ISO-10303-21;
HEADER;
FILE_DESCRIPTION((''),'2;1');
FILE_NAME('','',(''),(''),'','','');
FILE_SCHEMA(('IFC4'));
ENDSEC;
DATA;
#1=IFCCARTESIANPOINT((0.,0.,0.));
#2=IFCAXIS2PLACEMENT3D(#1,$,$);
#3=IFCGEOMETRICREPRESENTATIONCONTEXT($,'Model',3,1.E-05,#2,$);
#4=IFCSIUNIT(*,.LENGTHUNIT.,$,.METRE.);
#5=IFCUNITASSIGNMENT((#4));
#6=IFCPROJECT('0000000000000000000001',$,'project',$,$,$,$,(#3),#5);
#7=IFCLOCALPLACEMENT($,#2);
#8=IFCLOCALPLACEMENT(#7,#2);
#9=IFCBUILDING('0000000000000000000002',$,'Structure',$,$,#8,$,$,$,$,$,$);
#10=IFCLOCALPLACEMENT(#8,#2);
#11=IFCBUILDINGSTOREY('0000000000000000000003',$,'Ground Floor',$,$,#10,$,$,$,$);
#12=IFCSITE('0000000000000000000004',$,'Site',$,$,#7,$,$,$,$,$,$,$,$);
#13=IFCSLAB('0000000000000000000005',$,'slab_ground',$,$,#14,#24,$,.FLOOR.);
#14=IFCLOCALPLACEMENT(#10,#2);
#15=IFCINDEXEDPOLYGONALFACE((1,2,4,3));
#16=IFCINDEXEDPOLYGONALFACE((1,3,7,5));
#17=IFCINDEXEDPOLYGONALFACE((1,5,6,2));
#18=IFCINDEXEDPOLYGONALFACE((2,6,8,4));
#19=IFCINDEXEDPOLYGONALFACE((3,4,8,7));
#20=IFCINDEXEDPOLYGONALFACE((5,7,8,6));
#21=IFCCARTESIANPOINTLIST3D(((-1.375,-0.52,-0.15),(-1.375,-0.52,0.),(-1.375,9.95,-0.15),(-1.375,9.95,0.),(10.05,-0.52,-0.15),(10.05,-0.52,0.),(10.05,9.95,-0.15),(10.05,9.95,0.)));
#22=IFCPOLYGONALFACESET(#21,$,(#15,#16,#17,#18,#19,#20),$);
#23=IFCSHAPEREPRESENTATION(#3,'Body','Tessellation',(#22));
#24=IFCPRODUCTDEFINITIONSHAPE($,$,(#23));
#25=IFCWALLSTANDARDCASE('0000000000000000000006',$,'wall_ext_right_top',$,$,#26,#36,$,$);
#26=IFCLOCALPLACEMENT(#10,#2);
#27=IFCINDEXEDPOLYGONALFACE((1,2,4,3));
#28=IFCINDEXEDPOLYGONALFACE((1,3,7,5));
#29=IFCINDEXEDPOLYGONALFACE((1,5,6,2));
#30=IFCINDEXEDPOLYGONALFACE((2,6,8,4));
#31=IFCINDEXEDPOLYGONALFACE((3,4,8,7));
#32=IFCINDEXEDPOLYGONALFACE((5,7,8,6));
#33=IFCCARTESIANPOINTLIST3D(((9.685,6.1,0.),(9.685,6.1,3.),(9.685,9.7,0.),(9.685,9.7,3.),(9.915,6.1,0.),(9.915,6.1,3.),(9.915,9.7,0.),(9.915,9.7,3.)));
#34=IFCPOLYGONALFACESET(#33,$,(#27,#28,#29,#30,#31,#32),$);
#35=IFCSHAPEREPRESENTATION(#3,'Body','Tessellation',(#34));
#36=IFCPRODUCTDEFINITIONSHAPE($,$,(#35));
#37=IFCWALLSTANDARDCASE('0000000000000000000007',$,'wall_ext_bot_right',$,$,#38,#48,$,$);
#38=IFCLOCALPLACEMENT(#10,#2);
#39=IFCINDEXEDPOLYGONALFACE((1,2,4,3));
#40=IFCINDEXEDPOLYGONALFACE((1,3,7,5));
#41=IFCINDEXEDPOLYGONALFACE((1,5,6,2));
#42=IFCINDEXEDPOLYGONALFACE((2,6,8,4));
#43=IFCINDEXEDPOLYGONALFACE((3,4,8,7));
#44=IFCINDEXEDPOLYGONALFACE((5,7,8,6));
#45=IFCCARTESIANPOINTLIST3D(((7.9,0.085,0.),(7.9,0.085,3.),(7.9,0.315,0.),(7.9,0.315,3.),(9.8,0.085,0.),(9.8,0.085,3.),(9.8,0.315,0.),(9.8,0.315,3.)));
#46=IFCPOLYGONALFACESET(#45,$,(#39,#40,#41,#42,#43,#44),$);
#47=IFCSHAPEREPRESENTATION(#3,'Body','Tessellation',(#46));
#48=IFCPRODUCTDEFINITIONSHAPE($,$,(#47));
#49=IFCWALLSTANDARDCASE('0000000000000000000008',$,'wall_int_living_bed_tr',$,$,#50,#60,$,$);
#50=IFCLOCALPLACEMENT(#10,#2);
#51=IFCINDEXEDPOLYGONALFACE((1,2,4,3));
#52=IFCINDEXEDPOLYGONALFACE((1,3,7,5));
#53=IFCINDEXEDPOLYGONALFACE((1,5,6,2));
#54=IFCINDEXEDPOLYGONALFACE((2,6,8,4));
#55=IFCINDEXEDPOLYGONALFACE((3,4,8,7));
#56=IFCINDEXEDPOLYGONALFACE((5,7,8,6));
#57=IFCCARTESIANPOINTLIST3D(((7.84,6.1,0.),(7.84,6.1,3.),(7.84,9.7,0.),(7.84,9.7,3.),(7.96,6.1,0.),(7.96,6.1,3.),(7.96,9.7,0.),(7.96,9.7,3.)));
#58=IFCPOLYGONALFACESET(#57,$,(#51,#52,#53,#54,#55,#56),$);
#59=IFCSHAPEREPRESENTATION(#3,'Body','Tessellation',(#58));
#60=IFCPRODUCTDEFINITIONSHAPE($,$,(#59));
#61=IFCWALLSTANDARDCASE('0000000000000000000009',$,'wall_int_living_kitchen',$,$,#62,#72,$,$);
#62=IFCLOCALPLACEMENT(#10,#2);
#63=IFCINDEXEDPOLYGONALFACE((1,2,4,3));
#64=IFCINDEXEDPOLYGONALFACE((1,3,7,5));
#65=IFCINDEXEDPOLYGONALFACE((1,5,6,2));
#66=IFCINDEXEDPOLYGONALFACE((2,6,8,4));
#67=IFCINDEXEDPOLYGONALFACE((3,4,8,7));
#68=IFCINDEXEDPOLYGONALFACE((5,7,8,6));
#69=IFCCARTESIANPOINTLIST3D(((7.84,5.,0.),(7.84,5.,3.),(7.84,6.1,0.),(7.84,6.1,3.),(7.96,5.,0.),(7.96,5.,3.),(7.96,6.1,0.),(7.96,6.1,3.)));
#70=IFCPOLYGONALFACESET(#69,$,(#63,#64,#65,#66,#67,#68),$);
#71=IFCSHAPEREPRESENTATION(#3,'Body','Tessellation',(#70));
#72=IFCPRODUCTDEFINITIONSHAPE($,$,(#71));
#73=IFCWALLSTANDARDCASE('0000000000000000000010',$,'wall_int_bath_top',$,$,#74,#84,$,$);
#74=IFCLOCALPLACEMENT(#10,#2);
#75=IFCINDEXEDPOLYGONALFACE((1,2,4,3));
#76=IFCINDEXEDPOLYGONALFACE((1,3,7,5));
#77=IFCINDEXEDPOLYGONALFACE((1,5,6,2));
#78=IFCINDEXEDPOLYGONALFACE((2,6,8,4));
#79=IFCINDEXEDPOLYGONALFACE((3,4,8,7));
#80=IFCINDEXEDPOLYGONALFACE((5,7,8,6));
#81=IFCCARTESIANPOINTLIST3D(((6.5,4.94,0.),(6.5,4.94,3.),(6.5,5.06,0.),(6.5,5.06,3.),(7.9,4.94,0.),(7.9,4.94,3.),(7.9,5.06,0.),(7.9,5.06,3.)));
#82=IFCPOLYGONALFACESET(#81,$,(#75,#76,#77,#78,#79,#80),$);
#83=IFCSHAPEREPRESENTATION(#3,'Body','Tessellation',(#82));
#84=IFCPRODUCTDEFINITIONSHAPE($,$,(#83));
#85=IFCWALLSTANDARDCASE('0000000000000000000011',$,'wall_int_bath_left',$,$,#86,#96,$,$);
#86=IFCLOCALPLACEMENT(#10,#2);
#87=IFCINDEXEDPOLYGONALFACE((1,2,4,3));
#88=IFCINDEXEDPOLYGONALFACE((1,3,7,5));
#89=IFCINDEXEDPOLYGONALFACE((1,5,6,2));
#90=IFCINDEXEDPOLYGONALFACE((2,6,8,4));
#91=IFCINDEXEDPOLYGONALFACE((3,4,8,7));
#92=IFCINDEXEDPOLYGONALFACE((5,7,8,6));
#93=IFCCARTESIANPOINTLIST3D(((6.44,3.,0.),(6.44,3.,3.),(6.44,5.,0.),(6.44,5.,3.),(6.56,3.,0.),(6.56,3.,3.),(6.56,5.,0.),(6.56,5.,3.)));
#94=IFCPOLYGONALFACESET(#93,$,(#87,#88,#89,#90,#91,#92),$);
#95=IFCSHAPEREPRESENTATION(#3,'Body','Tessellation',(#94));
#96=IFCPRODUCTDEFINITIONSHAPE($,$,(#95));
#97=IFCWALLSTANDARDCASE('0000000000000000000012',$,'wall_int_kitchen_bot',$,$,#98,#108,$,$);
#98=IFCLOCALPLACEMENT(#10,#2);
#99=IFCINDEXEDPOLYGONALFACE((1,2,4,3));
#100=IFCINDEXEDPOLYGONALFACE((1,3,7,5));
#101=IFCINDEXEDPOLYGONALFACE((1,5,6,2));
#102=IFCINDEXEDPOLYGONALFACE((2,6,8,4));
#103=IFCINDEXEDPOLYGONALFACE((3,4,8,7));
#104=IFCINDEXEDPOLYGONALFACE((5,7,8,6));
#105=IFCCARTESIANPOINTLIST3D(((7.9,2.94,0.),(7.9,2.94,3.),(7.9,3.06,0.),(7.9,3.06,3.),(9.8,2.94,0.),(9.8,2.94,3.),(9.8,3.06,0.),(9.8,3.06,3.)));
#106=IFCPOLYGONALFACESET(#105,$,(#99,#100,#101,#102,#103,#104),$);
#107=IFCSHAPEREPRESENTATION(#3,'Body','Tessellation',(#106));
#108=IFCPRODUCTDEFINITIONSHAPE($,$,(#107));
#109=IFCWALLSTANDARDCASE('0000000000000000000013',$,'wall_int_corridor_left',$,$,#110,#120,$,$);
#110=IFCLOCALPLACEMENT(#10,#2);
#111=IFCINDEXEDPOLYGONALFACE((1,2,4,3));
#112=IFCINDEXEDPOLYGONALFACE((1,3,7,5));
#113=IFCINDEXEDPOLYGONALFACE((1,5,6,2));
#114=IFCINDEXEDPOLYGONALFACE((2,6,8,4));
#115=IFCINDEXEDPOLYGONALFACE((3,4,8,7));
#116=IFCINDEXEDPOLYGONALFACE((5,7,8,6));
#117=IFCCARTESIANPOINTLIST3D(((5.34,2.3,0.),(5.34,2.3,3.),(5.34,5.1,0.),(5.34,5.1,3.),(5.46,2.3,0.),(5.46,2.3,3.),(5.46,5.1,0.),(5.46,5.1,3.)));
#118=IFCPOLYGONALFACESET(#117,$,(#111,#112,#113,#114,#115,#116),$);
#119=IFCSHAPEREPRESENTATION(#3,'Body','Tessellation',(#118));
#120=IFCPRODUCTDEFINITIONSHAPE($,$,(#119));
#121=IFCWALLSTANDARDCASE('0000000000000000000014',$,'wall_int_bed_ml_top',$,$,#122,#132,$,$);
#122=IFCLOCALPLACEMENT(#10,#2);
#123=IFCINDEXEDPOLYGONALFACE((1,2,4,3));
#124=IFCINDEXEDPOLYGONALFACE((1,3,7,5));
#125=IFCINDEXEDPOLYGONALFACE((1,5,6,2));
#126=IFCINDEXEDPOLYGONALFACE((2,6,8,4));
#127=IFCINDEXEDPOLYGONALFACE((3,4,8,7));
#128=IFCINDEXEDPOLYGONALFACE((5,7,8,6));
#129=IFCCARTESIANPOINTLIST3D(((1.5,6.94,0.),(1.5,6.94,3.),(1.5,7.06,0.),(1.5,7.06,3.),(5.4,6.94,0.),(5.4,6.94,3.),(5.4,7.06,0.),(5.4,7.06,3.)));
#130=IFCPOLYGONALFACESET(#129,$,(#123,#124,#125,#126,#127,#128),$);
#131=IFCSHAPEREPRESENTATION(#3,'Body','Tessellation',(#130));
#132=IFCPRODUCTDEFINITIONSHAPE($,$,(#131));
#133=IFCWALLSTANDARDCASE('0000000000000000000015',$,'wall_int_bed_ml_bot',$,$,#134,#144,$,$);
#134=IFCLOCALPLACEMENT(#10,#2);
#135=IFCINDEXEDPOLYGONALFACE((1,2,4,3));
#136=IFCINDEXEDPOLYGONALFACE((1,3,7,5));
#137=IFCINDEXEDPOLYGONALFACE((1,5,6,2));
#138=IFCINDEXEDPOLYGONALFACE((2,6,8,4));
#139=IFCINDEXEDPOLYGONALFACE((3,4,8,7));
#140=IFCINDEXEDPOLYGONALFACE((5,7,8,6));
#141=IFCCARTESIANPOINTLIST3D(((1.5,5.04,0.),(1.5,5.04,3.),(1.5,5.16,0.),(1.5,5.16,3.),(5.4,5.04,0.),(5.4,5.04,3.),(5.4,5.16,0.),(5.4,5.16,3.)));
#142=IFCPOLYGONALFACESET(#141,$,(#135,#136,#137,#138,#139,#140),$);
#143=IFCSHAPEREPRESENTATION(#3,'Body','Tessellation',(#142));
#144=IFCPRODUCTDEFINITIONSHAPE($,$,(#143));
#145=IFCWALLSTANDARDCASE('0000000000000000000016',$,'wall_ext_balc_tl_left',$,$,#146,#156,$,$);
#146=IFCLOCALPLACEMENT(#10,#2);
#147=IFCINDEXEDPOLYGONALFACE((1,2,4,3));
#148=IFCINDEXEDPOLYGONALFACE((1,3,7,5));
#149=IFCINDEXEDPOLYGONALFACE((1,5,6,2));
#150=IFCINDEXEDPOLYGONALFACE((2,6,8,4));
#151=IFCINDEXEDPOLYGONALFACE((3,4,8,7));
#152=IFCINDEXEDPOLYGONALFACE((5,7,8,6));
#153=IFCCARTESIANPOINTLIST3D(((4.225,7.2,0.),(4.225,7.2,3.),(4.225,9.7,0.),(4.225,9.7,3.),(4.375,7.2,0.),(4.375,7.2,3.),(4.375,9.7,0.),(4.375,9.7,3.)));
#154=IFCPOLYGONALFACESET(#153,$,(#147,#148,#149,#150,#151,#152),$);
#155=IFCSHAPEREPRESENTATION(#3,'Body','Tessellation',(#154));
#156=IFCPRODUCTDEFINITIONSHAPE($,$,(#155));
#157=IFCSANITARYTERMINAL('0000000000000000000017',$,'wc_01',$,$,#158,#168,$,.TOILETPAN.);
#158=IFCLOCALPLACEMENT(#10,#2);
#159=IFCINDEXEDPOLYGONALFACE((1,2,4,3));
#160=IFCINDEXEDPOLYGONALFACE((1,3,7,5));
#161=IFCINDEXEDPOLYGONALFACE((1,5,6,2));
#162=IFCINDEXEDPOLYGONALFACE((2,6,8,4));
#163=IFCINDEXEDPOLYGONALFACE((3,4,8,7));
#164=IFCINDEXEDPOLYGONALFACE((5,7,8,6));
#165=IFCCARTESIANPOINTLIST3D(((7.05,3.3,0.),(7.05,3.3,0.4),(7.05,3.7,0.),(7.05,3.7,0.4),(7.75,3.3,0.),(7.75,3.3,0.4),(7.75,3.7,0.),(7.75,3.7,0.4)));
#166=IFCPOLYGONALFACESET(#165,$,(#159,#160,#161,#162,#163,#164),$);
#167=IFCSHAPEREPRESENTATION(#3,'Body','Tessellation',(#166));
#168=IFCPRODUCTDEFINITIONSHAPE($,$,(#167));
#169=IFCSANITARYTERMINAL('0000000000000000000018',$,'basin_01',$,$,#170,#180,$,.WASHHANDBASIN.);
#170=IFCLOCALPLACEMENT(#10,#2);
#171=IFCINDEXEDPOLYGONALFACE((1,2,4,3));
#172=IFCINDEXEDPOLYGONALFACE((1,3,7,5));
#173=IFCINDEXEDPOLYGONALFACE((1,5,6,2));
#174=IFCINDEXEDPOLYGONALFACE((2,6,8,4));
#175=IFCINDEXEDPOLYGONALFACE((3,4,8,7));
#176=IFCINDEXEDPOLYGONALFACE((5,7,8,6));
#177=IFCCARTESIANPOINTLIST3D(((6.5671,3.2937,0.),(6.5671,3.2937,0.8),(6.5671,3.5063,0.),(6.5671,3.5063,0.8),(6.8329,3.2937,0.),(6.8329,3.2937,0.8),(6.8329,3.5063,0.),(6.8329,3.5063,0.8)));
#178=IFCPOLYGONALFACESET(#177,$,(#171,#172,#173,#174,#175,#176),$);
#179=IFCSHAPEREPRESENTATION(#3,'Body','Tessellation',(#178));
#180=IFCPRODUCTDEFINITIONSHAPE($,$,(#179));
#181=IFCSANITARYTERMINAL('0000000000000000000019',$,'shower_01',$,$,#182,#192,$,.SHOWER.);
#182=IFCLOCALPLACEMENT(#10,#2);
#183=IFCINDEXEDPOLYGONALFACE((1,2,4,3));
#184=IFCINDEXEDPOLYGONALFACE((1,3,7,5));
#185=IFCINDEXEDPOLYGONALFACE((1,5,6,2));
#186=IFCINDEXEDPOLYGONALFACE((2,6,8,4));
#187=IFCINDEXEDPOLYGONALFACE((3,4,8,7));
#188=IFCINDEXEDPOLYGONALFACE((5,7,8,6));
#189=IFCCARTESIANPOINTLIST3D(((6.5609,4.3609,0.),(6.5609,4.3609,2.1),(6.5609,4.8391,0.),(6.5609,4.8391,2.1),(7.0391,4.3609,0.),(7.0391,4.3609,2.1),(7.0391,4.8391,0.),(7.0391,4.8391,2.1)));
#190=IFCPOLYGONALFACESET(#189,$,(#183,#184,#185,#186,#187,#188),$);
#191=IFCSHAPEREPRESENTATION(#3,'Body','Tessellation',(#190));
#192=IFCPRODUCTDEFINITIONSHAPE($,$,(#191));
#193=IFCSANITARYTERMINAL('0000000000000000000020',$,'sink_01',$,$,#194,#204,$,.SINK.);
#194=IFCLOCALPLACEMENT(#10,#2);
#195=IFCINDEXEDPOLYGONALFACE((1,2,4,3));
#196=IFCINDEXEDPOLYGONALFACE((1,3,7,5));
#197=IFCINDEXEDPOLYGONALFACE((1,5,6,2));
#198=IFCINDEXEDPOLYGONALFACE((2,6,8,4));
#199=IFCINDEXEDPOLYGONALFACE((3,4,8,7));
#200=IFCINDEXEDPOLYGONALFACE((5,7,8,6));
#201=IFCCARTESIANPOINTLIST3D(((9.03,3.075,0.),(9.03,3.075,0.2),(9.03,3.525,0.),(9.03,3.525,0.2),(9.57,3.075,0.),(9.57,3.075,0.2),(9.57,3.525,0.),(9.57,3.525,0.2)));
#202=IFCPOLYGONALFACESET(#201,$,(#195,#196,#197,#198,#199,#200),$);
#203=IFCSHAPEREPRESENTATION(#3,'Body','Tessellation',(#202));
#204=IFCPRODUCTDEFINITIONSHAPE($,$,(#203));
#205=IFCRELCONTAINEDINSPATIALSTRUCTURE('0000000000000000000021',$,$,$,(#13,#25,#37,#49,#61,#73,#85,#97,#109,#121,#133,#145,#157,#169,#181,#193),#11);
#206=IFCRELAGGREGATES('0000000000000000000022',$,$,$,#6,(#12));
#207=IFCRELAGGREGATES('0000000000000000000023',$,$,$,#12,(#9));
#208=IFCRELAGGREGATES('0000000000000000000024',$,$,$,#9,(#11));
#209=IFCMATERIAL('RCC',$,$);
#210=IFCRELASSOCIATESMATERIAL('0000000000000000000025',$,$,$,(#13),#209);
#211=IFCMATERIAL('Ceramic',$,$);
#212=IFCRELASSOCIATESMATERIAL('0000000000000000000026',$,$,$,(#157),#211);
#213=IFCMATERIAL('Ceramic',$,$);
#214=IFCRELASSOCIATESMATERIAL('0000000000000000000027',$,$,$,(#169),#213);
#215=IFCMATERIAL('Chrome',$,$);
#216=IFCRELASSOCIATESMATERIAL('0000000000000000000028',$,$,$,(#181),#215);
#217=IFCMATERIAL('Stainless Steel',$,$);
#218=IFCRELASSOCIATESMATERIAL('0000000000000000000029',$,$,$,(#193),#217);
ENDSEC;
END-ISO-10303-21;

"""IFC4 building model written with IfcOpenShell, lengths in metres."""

from ifc_helpers import new_model, si_unit, frame, origin, place, context, project, spatial, polyline, outline, extrude, material, element, save


model = new_model("IFC4")

# Units and contexts
model_context = context("Model", 3, precision=1e-05, world=origin())
ifc_project = project(units=[si_unit("LENGTHUNIT", "METRE")], contexts=[model_context])

# Site, building, storey
site_placement = place(None, origin())
site = spatial("IfcSite", under=ifc_project, at=site_placement, Name="Site")
building_placement = place(site_placement, origin())
building = spatial("IfcBuilding", under=site, at=building_placement, Name="Structure")
storey_placement = place(building_placement, origin())
storey = spatial("IfcBuildingStorey", under=building, at=storey_placement, Name="Ground Floor")

# Slab
ifc_material_1 = material(Name="RCC")
slab_placement = place(storey_placement, frame((0.0, 0.0, -0.15)))
element("IfcSlab", 1, at=slab_placement, inside=storey, material=ifc_material_1, Name="slab_ground", PredefinedType="FLOOR", context=model_context, shape_type="SweptSolid", body=[
    extrude(outline(polyline([(-1.375, -0.52), (10.05, -0.52), (10.05, 9.95), (-1.375, 9.95), (-1.375, -0.52)])), origin(), (0.0, 0.0, 1.0), 0.15),
])

# Walls
wall_1_placement = place(storey_placement, frame((9.8, 6.1, 0.0), x_axis=(0.0, 1.0, 0.0)))
element("IfcWallStandardCase", 2, at=wall_1_placement, inside=storey, Name="wall_ext_right_top", context=model_context, shape_type="SweptSolid", body=[
    extrude(outline(polyline([(0.0, -0.115), (3.6, -0.115), (3.6, 0.115), (0.0, 0.115), (0.0, -0.115)])), origin(), (0.0, 0.0, 1.0), 3.0),
])
wall_2_placement = place(storey_placement, frame((7.9, 0.2, 0.0), x_axis=(1.0, 0.0, 0.0)))
element("IfcWallStandardCase", 3, at=wall_2_placement, inside=storey, Name="wall_ext_bot_right", context=model_context, shape_type="SweptSolid", body=[
    extrude(outline(polyline([(0.0, -0.115), (1.9, -0.115), (1.9, 0.115), (0.0, 0.115), (0.0, -0.115)])), origin(), (0.0, 0.0, 1.0), 3.0),
])
wall_3_placement = place(storey_placement, frame((7.9, 6.1, 0.0), x_axis=(0.0, 1.0, 0.0)))
element("IfcWallStandardCase", 4, at=wall_3_placement, inside=storey, Name="wall_int_living_bed_tr", context=model_context, shape_type="SweptSolid", body=[
    extrude(outline(polyline([(0.0, -0.06), (3.6, -0.06), (3.6, 0.06), (0.0, 0.06), (0.0, -0.06)])), origin(), (0.0, 0.0, 1.0), 3.0),
])
wall_4_placement = place(storey_placement, frame((7.9, 5.0, 0.0), x_axis=(0.0, 1.0, 0.0)))
element("IfcWallStandardCase", 5, at=wall_4_placement, inside=storey, Name="wall_int_living_kitchen", context=model_context, shape_type="SweptSolid", body=[
    extrude(outline(polyline([(0.0, -0.06), (1.1, -0.06), (1.1, 0.06), (0.0, 0.06), (0.0, -0.06)])), origin(), (0.0, 0.0, 1.0), 3.0),
])
wall_5_placement = place(storey_placement, frame((6.5, 5.0, 0.0), x_axis=(1.0, 0.0, 0.0)))
element("IfcWallStandardCase", 6, at=wall_5_placement, inside=storey, Name="wall_int_bath_top", context=model_context, shape_type="SweptSolid", body=[
    extrude(outline(polyline([(0.0, -0.06), (1.4, -0.06), (1.4, 0.06), (0.0, 0.06), (0.0, -0.06)])), origin(), (0.0, 0.0, 1.0), 3.0),
])
wall_6_placement = place(storey_placement, frame((6.5, 3.0, 0.0), x_axis=(0.0, 1.0, 0.0)))
element("IfcWallStandardCase", 7, at=wall_6_placement, inside=storey, Name="wall_int_bath_left", context=model_context, shape_type="SweptSolid", body=[
    extrude(outline(polyline([(0.0, -0.06), (2.0, -0.06), (2.0, 0.06), (0.0, 0.06), (0.0, -0.06)])), origin(), (0.0, 0.0, 1.0), 3.0),
])
wall_7_placement = place(storey_placement, frame((7.9, 3.0, 0.0), x_axis=(1.0, 0.0, 0.0)))
element("IfcWallStandardCase", 8, at=wall_7_placement, inside=storey, Name="wall_int_kitchen_bot", context=model_context, shape_type="SweptSolid", body=[
    extrude(outline(polyline([(0.0, -0.06), (1.9, -0.06), (1.9, 0.06), (0.0, 0.06), (0.0, -0.06)])), origin(), (0.0, 0.0, 1.0), 3.0),
])
wall_8_placement = place(storey_placement, frame((5.4, 2.3, 0.0), x_axis=(0.0, 1.0, 0.0)))
element("IfcWallStandardCase", 9, at=wall_8_placement, inside=storey, Name="wall_int_corridor_left", context=model_context, shape_type="SweptSolid", body=[
    extrude(outline(polyline([(0.0, -0.06), (2.8, -0.06), (2.8, 0.06), (0.0, 0.06), (0.0, -0.06)])), origin(), (0.0, 0.0, 1.0), 3.0),
])
for number, where, x_axis, name in (
    (10, (1.5, 7.0, 0.0), (1.0, 0.0, 0.0), "wall_int_bed_ml_top"),
    (11, (1.5, 5.1, 0.0), (1.0, 0.0, 0.0), "wall_int_bed_ml_bot"),
):
    element("IfcWallStandardCase", number, at=place(storey_placement, frame(where, x_axis=x_axis)), inside=storey, Name=name, context=model_context, shape_type="SweptSolid", body=[
        extrude(outline(polyline([(0.0, -0.06), (3.9, -0.06), (3.9, 0.06), (0.0, 0.06), (0.0, -0.06)])), origin(), (0.0, 0.0, 1.0), 3.0),
    ])
wall_9_placement = place(storey_placement, frame((4.3, 7.2, 0.0), x_axis=(0.0, 1.0, 0.0)))
element("IfcWallStandardCase", 12, at=wall_9_placement, inside=storey, Name="wall_ext_balc_tl_left", context=model_context, shape_type="SweptSolid", body=[
    extrude(outline(polyline([(0.0, -0.075), (2.5, -0.075), (2.5, 0.075), (0.0, 0.075), (0.0, -0.075)])), origin(), (0.0, 0.0, 1.0), 3.0),
])

# Sanitary terminals
ifc_material_2 = material(Name="Ceramic")
sanitary_terminal_1_placement = place(storey_placement, frame((7.4, 3.5, 0.0)))
element("IfcSanitaryTerminal", 13, at=sanitary_terminal_1_placement, inside=storey, material=ifc_material_2, Name="wc_01", PredefinedType="TOILETPAN", context=model_context, shape_type="SweptSolid", body=[
    extrude(outline(polyline([(-0.35, -0.2), (0.35, -0.2), (0.35, 0.2), (-0.35, 0.2), (-0.35, -0.2)])), origin(), (0.0, 0.0, 1.0), 0.4),
])
ifc_material_3 = material(Name="Ceramic")
sanitary_terminal_2_placement = place(storey_placement, frame((6.7, 3.4, 0.0)))
element("IfcSanitaryTerminal", 14, at=sanitary_terminal_2_placement, inside=storey, material=ifc_material_3, Name="basin_01", PredefinedType="WASHHANDBASIN", context=model_context, shape_type="SweptSolid", body=[
    extrude(outline(polyline([(-0.1329, -0.1063), (0.1329, -0.1063), (0.1329, 0.1063), (-0.1329, 0.1063), (-0.1329, -0.1063)])), origin(), (0.0, 0.0, 1.0), 0.8),
])
ifc_material_4 = material(Name="Chrome")
sanitary_terminal_3_placement = place(storey_placement, frame((6.8, 4.6, 0.0)))
element("IfcSanitaryTerminal", 15, at=sanitary_terminal_3_placement, inside=storey, material=ifc_material_4, Name="shower_01", PredefinedType="SHOWER", context=model_context, shape_type="SweptSolid", body=[
    extrude(outline(polyline([(-0.2391, -0.2391), (0.2391, -0.2391), (0.2391, 0.2391), (-0.2391, 0.2391), (-0.2391, -0.2391)])), origin(), (0.0, 0.0, 1.0), 2.1),
])
ifc_material_5 = material(Name="Stainless Steel")
sanitary_terminal_4_placement = place(storey_placement, frame((9.3, 3.3, 0.0)))
element("IfcSanitaryTerminal", 16, at=sanitary_terminal_4_placement, inside=storey, material=ifc_material_5, Name="sink_01", PredefinedType="SINK", context=model_context, shape_type="SweptSolid", body=[
    extrude(outline(polyline([(-0.27, -0.225), (0.27, -0.225), (0.27, 0.225), (-0.27, 0.225), (-0.27, -0.225)])), origin(), (0.0, 0.0, 1.0), 0.2),
])

save(model, "model.ifc")
